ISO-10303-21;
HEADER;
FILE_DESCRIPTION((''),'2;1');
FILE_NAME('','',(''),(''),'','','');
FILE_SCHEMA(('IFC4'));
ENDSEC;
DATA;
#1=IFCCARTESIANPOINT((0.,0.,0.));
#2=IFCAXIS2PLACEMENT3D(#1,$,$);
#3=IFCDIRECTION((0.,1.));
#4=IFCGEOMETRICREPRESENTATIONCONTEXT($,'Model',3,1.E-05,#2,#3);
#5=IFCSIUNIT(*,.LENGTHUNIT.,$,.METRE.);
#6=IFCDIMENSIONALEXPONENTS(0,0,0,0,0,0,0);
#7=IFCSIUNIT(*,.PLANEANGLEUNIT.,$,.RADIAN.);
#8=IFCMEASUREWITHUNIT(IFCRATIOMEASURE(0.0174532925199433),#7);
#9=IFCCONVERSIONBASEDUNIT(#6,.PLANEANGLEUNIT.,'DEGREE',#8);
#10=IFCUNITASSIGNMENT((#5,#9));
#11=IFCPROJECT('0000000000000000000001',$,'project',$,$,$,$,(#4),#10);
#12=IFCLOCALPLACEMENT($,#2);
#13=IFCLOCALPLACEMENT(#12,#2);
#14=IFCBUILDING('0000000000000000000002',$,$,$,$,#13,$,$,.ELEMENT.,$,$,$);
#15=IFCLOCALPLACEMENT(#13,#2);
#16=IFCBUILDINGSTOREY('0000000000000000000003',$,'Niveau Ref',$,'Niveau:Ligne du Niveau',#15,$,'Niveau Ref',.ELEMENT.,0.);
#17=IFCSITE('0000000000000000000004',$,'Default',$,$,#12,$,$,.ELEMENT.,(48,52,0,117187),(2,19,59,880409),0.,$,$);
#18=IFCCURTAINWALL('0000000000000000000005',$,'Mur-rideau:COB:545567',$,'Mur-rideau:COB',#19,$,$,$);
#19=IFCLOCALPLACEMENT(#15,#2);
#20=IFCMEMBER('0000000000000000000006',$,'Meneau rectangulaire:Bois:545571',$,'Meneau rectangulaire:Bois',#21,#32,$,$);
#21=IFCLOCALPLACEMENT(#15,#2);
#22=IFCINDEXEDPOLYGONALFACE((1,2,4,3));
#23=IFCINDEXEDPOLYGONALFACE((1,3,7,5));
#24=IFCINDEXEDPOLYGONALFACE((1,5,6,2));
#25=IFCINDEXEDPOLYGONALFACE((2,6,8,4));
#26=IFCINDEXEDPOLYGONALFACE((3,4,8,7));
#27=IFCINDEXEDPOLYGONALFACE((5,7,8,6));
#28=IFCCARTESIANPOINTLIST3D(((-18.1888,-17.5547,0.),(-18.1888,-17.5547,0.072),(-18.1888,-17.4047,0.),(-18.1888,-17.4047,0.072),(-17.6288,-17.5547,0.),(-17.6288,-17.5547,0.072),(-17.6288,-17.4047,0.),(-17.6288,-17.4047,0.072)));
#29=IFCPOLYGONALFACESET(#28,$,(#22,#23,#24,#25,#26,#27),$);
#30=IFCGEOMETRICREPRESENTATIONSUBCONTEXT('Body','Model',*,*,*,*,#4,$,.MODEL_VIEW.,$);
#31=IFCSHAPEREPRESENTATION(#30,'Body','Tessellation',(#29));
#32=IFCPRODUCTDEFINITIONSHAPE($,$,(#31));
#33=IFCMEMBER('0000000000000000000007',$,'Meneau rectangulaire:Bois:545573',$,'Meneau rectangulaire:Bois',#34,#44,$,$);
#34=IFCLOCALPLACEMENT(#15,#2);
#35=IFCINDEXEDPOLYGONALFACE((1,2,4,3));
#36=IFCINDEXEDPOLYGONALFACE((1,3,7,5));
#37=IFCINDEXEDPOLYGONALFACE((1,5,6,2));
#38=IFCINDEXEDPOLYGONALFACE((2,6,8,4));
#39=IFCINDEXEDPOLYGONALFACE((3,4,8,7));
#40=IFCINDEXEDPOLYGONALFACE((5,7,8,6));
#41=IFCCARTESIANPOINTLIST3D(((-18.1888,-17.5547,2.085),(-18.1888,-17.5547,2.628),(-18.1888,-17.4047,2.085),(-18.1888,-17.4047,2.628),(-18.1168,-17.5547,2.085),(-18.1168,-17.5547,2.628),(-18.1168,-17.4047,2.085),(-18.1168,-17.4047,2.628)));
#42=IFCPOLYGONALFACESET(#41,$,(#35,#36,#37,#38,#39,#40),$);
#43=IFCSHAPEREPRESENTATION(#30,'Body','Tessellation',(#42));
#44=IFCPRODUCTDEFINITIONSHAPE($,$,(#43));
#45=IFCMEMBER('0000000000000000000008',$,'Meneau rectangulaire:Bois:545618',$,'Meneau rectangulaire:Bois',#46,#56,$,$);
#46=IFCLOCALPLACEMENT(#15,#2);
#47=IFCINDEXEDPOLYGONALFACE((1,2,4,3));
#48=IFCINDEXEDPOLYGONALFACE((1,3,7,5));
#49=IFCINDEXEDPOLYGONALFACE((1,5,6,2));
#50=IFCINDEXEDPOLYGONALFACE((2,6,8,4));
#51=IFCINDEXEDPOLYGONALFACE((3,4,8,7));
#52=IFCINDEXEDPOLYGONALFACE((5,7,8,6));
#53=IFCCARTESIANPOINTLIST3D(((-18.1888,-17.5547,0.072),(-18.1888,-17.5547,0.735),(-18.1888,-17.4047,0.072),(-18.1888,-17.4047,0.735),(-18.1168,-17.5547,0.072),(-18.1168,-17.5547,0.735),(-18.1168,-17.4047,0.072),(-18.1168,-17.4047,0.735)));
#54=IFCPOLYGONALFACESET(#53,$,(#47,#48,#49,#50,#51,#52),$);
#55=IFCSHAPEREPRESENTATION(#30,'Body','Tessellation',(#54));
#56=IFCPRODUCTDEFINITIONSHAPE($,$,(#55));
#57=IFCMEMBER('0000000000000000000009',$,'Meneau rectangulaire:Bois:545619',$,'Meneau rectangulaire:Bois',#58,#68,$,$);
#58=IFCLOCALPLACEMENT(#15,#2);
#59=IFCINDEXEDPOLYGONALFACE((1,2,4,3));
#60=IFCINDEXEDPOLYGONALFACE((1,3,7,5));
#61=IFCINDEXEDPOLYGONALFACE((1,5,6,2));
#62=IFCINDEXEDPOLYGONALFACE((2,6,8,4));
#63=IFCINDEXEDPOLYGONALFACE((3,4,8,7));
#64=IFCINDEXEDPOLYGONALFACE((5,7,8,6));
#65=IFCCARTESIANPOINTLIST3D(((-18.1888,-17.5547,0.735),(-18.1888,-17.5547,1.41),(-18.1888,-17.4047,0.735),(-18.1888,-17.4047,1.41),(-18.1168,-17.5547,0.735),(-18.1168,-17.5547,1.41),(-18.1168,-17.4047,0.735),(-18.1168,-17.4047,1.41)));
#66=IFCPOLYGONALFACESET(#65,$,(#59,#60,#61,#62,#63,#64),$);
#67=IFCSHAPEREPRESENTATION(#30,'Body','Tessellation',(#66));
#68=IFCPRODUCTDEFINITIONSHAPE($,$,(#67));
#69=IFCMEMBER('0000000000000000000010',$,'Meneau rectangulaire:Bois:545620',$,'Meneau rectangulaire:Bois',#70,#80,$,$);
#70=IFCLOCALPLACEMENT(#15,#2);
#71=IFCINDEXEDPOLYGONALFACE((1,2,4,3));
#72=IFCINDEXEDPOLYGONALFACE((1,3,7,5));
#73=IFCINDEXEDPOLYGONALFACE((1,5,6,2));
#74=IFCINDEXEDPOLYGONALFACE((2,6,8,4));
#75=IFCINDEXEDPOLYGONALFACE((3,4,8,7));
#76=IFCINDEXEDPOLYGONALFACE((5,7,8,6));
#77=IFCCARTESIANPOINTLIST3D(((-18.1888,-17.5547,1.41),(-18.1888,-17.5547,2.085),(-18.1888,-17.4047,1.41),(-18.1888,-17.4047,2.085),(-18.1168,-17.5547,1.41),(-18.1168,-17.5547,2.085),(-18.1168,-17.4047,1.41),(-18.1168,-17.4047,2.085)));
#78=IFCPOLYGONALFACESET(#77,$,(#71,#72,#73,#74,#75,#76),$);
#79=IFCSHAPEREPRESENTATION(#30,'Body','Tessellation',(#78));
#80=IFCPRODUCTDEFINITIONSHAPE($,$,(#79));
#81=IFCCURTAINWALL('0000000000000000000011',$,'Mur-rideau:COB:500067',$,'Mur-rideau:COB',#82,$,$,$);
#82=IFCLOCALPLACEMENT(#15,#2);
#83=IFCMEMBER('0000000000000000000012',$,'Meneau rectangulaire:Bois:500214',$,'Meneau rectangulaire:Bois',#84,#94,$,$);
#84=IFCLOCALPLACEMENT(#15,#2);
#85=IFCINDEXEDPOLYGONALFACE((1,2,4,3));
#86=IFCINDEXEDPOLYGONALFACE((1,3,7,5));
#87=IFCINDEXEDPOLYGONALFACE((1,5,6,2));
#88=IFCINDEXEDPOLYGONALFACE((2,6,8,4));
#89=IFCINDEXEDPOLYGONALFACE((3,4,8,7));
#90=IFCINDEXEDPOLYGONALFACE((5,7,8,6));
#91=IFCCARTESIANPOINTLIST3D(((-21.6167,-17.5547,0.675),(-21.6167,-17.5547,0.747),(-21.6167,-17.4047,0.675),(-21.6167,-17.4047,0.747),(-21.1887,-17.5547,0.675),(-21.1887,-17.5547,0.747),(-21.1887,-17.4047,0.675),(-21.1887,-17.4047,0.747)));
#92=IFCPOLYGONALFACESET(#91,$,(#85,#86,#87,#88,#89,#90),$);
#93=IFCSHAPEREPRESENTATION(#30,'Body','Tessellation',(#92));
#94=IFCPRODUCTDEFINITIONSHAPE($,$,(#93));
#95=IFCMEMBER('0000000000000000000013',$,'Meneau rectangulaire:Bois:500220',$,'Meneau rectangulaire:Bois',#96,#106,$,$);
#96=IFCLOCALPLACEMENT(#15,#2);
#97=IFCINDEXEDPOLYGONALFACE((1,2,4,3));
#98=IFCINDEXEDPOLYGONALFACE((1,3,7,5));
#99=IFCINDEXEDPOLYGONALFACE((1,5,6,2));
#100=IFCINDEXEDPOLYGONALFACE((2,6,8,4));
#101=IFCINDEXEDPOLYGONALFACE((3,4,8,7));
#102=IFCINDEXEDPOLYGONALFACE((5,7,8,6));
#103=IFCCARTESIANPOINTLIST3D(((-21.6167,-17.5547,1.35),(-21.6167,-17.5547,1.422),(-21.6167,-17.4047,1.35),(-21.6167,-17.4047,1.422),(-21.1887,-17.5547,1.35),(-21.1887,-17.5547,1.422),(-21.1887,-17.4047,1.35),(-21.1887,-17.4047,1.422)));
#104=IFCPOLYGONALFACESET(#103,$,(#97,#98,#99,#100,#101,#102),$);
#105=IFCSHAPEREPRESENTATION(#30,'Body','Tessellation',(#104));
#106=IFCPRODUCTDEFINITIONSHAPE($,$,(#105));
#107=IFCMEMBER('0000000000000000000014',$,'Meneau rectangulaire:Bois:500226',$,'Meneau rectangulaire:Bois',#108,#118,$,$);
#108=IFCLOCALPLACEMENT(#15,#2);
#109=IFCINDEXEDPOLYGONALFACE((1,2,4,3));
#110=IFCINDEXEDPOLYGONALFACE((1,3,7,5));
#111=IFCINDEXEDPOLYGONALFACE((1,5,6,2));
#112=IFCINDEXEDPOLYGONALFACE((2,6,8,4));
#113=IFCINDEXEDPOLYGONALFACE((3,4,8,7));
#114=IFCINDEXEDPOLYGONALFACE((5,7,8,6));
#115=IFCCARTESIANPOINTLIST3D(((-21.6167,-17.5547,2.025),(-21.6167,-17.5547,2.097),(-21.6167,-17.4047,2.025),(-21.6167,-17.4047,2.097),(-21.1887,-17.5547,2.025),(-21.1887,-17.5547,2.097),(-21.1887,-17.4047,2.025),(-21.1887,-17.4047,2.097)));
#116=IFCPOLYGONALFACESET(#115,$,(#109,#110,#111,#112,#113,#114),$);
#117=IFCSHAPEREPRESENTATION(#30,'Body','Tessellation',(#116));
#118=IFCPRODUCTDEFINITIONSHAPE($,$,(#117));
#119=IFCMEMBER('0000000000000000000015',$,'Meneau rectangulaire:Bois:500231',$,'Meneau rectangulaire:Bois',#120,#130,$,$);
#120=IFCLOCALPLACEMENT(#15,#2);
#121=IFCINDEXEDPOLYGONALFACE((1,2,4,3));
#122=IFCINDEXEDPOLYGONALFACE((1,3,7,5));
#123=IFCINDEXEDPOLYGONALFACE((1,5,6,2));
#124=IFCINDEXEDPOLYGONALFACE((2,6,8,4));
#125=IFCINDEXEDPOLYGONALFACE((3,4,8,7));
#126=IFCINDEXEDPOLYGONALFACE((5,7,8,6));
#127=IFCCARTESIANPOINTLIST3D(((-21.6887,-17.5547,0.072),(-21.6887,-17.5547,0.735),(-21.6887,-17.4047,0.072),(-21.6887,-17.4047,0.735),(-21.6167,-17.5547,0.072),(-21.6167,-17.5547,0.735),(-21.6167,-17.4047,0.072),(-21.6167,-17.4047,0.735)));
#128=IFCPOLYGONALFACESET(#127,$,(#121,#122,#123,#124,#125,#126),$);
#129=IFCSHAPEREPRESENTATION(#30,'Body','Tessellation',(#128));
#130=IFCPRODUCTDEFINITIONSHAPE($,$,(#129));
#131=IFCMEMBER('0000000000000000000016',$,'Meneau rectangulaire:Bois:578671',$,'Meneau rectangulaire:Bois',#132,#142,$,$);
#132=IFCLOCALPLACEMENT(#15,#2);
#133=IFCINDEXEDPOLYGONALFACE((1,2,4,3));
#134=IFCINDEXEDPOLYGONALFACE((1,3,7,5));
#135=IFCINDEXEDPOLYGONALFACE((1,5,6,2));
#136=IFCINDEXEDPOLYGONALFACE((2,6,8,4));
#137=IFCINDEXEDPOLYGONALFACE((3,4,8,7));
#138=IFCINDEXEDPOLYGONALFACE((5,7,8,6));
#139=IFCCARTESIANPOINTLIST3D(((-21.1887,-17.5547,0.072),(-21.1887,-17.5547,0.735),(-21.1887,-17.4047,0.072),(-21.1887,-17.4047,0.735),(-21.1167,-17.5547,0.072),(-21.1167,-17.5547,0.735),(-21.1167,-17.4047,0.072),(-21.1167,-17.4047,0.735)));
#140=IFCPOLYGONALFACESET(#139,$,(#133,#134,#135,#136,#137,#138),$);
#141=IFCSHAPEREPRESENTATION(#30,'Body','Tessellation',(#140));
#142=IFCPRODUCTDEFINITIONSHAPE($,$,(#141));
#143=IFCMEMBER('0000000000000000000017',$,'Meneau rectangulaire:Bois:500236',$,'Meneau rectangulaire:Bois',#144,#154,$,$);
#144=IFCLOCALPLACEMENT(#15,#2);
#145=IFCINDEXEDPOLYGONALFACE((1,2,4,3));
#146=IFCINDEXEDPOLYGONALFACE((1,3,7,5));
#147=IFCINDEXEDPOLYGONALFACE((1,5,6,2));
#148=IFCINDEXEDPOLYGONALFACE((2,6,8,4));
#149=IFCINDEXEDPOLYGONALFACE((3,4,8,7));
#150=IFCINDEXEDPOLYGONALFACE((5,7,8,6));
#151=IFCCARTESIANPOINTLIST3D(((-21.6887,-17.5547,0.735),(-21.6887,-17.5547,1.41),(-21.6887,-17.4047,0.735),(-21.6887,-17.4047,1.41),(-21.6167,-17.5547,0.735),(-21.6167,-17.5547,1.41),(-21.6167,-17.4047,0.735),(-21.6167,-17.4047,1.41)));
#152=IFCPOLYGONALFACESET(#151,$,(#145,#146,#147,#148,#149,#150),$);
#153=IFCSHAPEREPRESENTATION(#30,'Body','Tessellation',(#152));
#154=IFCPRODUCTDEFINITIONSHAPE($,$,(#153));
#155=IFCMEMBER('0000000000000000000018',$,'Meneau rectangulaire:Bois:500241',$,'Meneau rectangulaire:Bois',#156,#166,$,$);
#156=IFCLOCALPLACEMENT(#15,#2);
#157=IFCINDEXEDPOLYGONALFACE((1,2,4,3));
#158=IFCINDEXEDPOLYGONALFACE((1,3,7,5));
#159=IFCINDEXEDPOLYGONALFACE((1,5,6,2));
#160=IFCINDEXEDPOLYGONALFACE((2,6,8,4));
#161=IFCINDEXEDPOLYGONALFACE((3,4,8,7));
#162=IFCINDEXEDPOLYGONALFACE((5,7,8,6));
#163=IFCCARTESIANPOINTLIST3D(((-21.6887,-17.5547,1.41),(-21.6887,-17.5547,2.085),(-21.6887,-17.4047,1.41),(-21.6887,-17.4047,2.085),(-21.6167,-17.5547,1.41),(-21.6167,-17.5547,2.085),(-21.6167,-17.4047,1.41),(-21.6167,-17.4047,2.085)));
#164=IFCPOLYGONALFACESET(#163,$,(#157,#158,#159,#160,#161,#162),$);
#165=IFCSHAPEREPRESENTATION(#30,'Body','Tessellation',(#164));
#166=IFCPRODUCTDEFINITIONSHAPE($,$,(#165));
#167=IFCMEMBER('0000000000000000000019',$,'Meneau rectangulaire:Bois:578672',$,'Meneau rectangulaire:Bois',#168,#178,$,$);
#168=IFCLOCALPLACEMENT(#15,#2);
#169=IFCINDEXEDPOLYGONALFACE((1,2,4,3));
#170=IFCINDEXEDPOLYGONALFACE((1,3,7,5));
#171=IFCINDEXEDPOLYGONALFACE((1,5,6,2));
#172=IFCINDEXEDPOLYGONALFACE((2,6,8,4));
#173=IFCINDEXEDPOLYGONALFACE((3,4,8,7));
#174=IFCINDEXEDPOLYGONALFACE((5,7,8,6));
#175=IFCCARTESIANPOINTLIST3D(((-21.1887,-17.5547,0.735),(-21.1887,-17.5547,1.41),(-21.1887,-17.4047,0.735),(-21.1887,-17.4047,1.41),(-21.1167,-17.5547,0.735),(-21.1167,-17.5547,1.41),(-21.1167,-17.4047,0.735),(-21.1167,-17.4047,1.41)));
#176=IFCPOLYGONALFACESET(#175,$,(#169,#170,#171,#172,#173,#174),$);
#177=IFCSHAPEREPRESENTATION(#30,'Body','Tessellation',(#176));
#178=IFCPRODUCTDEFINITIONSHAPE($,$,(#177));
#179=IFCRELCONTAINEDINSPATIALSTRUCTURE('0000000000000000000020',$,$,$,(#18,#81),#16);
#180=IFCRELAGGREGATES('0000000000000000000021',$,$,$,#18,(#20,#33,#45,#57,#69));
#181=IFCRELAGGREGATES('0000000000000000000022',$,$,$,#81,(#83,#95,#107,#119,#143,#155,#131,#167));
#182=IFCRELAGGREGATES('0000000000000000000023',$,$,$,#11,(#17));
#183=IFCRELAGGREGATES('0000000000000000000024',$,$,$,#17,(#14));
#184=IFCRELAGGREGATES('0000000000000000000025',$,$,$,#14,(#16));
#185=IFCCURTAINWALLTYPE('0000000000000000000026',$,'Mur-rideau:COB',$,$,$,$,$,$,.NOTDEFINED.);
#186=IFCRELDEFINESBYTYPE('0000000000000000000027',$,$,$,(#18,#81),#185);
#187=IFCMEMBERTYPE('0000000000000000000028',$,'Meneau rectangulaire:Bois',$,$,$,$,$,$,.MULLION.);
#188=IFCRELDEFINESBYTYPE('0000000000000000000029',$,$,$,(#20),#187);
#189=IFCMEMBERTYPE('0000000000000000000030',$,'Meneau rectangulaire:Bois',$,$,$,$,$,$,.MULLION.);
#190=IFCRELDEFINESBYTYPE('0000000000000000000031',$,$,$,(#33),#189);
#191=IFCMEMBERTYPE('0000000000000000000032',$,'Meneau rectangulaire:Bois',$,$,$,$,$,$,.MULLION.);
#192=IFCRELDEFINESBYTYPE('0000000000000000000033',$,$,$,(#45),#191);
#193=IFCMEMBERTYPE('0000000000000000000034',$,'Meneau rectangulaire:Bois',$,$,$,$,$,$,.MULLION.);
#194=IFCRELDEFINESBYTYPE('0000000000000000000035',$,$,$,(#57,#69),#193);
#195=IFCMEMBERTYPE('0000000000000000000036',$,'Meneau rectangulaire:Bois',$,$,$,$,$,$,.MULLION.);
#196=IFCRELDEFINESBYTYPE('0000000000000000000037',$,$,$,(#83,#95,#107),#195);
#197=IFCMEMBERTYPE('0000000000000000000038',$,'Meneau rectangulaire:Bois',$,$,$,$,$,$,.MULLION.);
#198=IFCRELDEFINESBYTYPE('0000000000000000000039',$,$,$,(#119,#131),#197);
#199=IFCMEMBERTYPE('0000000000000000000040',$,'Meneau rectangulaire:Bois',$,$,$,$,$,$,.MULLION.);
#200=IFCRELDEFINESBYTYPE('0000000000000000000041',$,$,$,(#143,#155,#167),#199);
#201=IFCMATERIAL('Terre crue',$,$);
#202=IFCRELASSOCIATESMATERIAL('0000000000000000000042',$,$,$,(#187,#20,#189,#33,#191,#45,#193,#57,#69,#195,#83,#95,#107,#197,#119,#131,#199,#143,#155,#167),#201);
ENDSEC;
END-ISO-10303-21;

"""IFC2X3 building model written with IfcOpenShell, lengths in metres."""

from ifc_helpers import new_model, entity, si_unit, converted_unit, direction, frame, origin, origin_2d_with_axis, place, context, subcontext, project, spatial, rectangle, extrude, source, transform, mapped, material, type_object, type_shapes, element, aggregate, save


model = new_model("IFC2X3")

# Units and contexts
model_context = context("Model", 3, precision=1e-05, world=origin(), true_north=direction((0.0, 1.0)))
body_context = subcontext(model_context, "Body", "Model", "MODEL_VIEW")
ifc_project = project(units=[si_unit("LENGTHUNIT", "METRE"), converted_unit("PLANEANGLEUNIT", "DEGREE", entity("IfcRatioMeasure", 0.0174532925199433), si_unit("PLANEANGLEUNIT", "RADIAN"), dimensions=[0, 0, 0, 0, 0, 0, 0])], contexts=[model_context])

# Site, building, storey
site_placement = place(None, origin())
site = spatial("IfcSite", under=ifc_project, at=site_placement, Name="Default", CompositionType="ELEMENT", RefLatitude=(48, 52, 0, 117187), RefLongitude=(2, 19, 59, 880409), RefElevation=0.0)
building_placement = place(site_placement, origin())
building = spatial("IfcBuilding", under=site, at=building_placement, CompositionType="ELEMENT")
storey_placement = place(building_placement, origin())
storey = spatial("IfcBuildingStorey", under=building, at=storey_placement, Name="Niveau Ref", ObjectType="Niveau:Ligne du Niveau", LongName="Niveau Ref", CompositionType="ELEMENT", Elevation=0.0)

# Curtain walls, members
curtain_wall_type_1 = type_object("IfcCurtainWallType", Name="Mur-rideau:COB", PredefinedType="NOTDEFINED")
curtain_wall_1_placement = place(storey_placement, origin())
curtain_wall_1 = element("IfcCurtainWall", 1, at=curtain_wall_1_placement, inside=storey, type_object=curtain_wall_type_1, Name="Mur-rideau:COB:545567", ObjectType="Mur-rideau:COB")
ifc_material_1 = material(Name="Terre crue")
member_type_1 = type_object("IfcMemberType", Name="Meneau rectangulaire:Bois", PredefinedType="MULLION", material=ifc_material_1)
shared_shape_1 = source(origin(), body_context, "Body", "SweptSolid", [
    extrude(rectangle(XDim=0.15, YDim=0.072, at=origin_2d_with_axis()), frame((-0.036, 0.0, -0.56), z_axis=(0.0, 0.0, 1.0), x_axis=(0.0, -1.0, 0.0)), (0.0, 0.0, 1.0), 0.56),
])
type_shapes(member_type_1, [shared_shape_1])
member_1_placement = place(storey_placement, frame((-18.1888, -17.4797, 0.0), z_axis=(-1.0, 0.0, 0.0), x_axis=(0.0, 0.0, -1.0)))
member_1 = element("IfcMember", 2, at=member_1_placement, type_object=member_type_1, material=ifc_material_1, Name="Meneau rectangulaire:Bois:545571", ObjectType="Meneau rectangulaire:Bois", context=body_context, shape_type="MappedRepresentation", body=[
    mapped(shared_shape_1, transform((0.0, 0.0, 0.0), scale=1.0)),
])
member_type_2 = type_object("IfcMemberType", Name="Meneau rectangulaire:Bois", PredefinedType="MULLION", material=ifc_material_1)
shared_shape_2 = source(origin(), body_context, "Body", "SweptSolid", [
    extrude(rectangle(XDim=0.15, YDim=0.072, at=origin_2d_with_axis()), frame((-0.036, 0.0, -0.543), z_axis=(0.0, 0.0, 1.0), x_axis=(0.0, -1.0, 0.0)), (0.0, 0.0, 1.0), 0.543),
])
type_shapes(member_type_2, [shared_shape_2])
member_2_placement = place(storey_placement, frame((-18.1888, -17.4797, 2.628), z_axis=(0.0, 0.0, 1.0), x_axis=(-1.0, 0.0, 0.0)))
member_2 = element("IfcMember", 3, at=member_2_placement, type_object=member_type_2, material=ifc_material_1, Name="Meneau rectangulaire:Bois:545573", ObjectType="Meneau rectangulaire:Bois", context=body_context, shape_type="MappedRepresentation", body=[
    mapped(shared_shape_2, transform((0.0, 0.0, 0.0), scale=1.0)),
])
member_type_3 = type_object("IfcMemberType", Name="Meneau rectangulaire:Bois", PredefinedType="MULLION", material=ifc_material_1)
shared_shape_3 = source(origin(), body_context, "Body", "SweptSolid", [
    extrude(rectangle(XDim=0.15, YDim=0.072, at=origin_2d_with_axis()), frame((-0.036, 0.0, -0.663), z_axis=(0.0, 0.0, 1.0), x_axis=(0.0, -1.0, 0.0)), (0.0, 0.0, 1.0), 0.663),
])
type_shapes(member_type_3, [shared_shape_3])
member_3_placement = place(storey_placement, frame((-18.1888, -17.4797, 0.735), z_axis=(0.0, 0.0, 1.0), x_axis=(-1.0, 0.0, 0.0)))
member_3 = element("IfcMember", 4, at=member_3_placement, type_object=member_type_3, material=ifc_material_1, Name="Meneau rectangulaire:Bois:545618", ObjectType="Meneau rectangulaire:Bois", context=body_context, shape_type="MappedRepresentation", body=[
    mapped(shared_shape_3, transform((0.0, 0.0, 0.0), scale=1.0)),
])
member_type_4 = type_object("IfcMemberType", Name="Meneau rectangulaire:Bois", PredefinedType="MULLION", material=ifc_material_1)
shared_shape_4 = source(origin(), body_context, "Body", "SweptSolid", [
    extrude(rectangle(XDim=0.15, YDim=0.072, at=origin_2d_with_axis()), frame((-0.036, 0.0, -0.675), z_axis=(0.0, 0.0, 1.0), x_axis=(0.0, -1.0, 0.0)), (0.0, 0.0, 1.0), 0.675),
])
type_shapes(member_type_4, [shared_shape_4])
member_4_placement = place(storey_placement, frame((-18.1888, -17.4797, 1.41), z_axis=(0.0, 0.0, 1.0), x_axis=(-1.0, 0.0, 0.0)))
member_4 = element("IfcMember", 5, at=member_4_placement, type_object=member_type_4, material=ifc_material_1, Name="Meneau rectangulaire:Bois:545619", ObjectType="Meneau rectangulaire:Bois", context=body_context, shape_type="MappedRepresentation", body=[
    mapped(shared_shape_4, transform((0.0, 0.0, 0.0), scale=1.0)),
])
member_5_placement = place(storey_placement, frame((-18.1888, -17.4797, 2.085), z_axis=(0.0, 0.0, 1.0), x_axis=(-1.0, 0.0, 0.0)))
member_5 = element("IfcMember", 6, at=member_5_placement, type_object=member_type_4, material=ifc_material_1, Name="Meneau rectangulaire:Bois:545620", ObjectType="Meneau rectangulaire:Bois", context=body_context, shape_type="MappedRepresentation", body=[
    mapped(shared_shape_4, transform((0.0, 0.0, 0.0), scale=1.0)),
])
aggregate(curtain_wall_1, [member_1, member_2, member_3, member_4, member_5])
curtain_wall_2_placement = place(storey_placement, origin())
curtain_wall_2 = element("IfcCurtainWall", 7, at=curtain_wall_2_placement, inside=storey, type_object=curtain_wall_type_1, Name="Mur-rideau:COB:500067", ObjectType="Mur-rideau:COB")
member_type_5 = type_object("IfcMemberType", Name="Meneau rectangulaire:Bois", PredefinedType="MULLION", material=ifc_material_1)
shared_shape_5 = source(origin(), body_context, "Body", "SweptSolid", [
    extrude(rectangle(XDim=0.15, YDim=0.072, at=origin_2d_with_axis()), frame((-0.024, 0.0, -0.428), z_axis=(0.0, 0.0, 1.0), x_axis=(0.0, -1.0, 0.0)), (0.0, 0.0, 1.0), 0.428),
])
type_shapes(member_type_5, [shared_shape_5])
member_6_placement = place(storey_placement, frame((-21.1887, -17.4797, 0.735), z_axis=(1.0, 0.0, 0.0), x_axis=(0.0, 0.0, 1.0)))
member_6 = element("IfcMember", 8, at=member_6_placement, type_object=member_type_5, material=ifc_material_1, Name="Meneau rectangulaire:Bois:500214", ObjectType="Meneau rectangulaire:Bois", context=body_context, shape_type="MappedRepresentation", body=[
    mapped(shared_shape_5, transform((0.0, 0.0, 0.0), scale=1.0)),
])
member_7_placement = place(storey_placement, frame((-21.1887, -17.4797, 1.41), z_axis=(1.0, 0.0, 0.0), x_axis=(0.0, 0.0, 1.0)))
member_7 = element("IfcMember", 9, at=member_7_placement, type_object=member_type_5, material=ifc_material_1, Name="Meneau rectangulaire:Bois:500220", ObjectType="Meneau rectangulaire:Bois", context=body_context, shape_type="MappedRepresentation", body=[
    mapped(shared_shape_5, transform((0.0, 0.0, 0.0), scale=1.0)),
])
member_8_placement = place(storey_placement, frame((-21.1887, -17.4797, 2.085), z_axis=(1.0, 0.0, 0.0), x_axis=(0.0, 0.0, 1.0)))
member_8 = element("IfcMember", 10, at=member_8_placement, type_object=member_type_5, material=ifc_material_1, Name="Meneau rectangulaire:Bois:500226", ObjectType="Meneau rectangulaire:Bois", context=body_context, shape_type="MappedRepresentation", body=[
    mapped(shared_shape_5, transform((0.0, 0.0, 0.0), scale=1.0)),
])
member_type_6 = type_object("IfcMemberType", Name="Meneau rectangulaire:Bois", PredefinedType="MULLION", material=ifc_material_1)
shared_shape_6 = source(origin(), body_context, "Body", "SweptSolid", [
    extrude(rectangle(XDim=0.15, YDim=0.072, at=origin_2d_with_axis()), frame((-0.024, 0.0, -0.663), z_axis=(0.0, 0.0, 1.0), x_axis=(0.0, -1.0, 0.0)), (0.0, 0.0, 1.0), 0.663),
])
type_shapes(member_type_6, [shared_shape_6])
member_9_placement = place(storey_placement, frame((-21.6287, -17.4797, 0.072), z_axis=(0.0, 0.0, -1.0), x_axis=(1.0, 0.0, 0.0)))
member_9 = element("IfcMember", 11, at=member_9_placement, type_object=member_type_6, material=ifc_material_1, Name="Meneau rectangulaire:Bois:500231", ObjectType="Meneau rectangulaire:Bois", context=body_context, shape_type="MappedRepresentation", body=[
    mapped(shared_shape_6, transform((0.0, 0.0, 0.0), scale=1.0)),
])
member_10_placement = place(storey_placement, frame((-21.1287, -17.4797, 0.072), z_axis=(0.0, 0.0, -1.0), x_axis=(1.0, 0.0, 0.0)))
member_10 = element("IfcMember", 12, at=member_10_placement, type_object=member_type_6, material=ifc_material_1, Name="Meneau rectangulaire:Bois:578671", ObjectType="Meneau rectangulaire:Bois", context=body_context, shape_type="MappedRepresentation", body=[
    mapped(shared_shape_6, transform((0.0, 0.0, 0.0), scale=1.0)),
])
member_type_7 = type_object("IfcMemberType", Name="Meneau rectangulaire:Bois", PredefinedType="MULLION", material=ifc_material_1)
shared_shape_7 = source(origin(), body_context, "Body", "SweptSolid", [
    extrude(rectangle(XDim=0.15, YDim=0.072, at=origin_2d_with_axis()), frame((-0.024, 0.0, -0.675), z_axis=(0.0, 0.0, 1.0), x_axis=(0.0, -1.0, 0.0)), (0.0, 0.0, 1.0), 0.675),
])
type_shapes(member_type_7, [shared_shape_7])
member_11_placement = place(storey_placement, frame((-21.6287, -17.4797, 0.735), z_axis=(0.0, 0.0, -1.0), x_axis=(1.0, 0.0, 0.0)))
member_11 = element("IfcMember", 13, at=member_11_placement, type_object=member_type_7, material=ifc_material_1, Name="Meneau rectangulaire:Bois:500236", ObjectType="Meneau rectangulaire:Bois", context=body_context, shape_type="MappedRepresentation", body=[
    mapped(shared_shape_7, transform((0.0, 0.0, 0.0), scale=1.0)),
])
member_12_placement = place(storey_placement, frame((-21.6287, -17.4797, 1.41), z_axis=(0.0, 0.0, -1.0), x_axis=(1.0, 0.0, 0.0)))
member_12 = element("IfcMember", 14, at=member_12_placement, type_object=member_type_7, material=ifc_material_1, Name="Meneau rectangulaire:Bois:500241", ObjectType="Meneau rectangulaire:Bois", context=body_context, shape_type="MappedRepresentation", body=[
    mapped(shared_shape_7, transform((0.0, 0.0, 0.0), scale=1.0)),
])
member_13_placement = place(storey_placement, frame((-21.1287, -17.4797, 0.735), z_axis=(0.0, 0.0, -1.0), x_axis=(1.0, 0.0, 0.0)))
member_13 = element("IfcMember", 15, at=member_13_placement, type_object=member_type_7, material=ifc_material_1, Name="Meneau rectangulaire:Bois:578672", ObjectType="Meneau rectangulaire:Bois", context=body_context, shape_type="MappedRepresentation", body=[
    mapped(shared_shape_7, transform((0.0, 0.0, 0.0), scale=1.0)),
])
aggregate(curtain_wall_2, [member_6, member_7, member_8, member_9, member_11, member_12, member_10, member_13])

save(model, "model.ifc")
